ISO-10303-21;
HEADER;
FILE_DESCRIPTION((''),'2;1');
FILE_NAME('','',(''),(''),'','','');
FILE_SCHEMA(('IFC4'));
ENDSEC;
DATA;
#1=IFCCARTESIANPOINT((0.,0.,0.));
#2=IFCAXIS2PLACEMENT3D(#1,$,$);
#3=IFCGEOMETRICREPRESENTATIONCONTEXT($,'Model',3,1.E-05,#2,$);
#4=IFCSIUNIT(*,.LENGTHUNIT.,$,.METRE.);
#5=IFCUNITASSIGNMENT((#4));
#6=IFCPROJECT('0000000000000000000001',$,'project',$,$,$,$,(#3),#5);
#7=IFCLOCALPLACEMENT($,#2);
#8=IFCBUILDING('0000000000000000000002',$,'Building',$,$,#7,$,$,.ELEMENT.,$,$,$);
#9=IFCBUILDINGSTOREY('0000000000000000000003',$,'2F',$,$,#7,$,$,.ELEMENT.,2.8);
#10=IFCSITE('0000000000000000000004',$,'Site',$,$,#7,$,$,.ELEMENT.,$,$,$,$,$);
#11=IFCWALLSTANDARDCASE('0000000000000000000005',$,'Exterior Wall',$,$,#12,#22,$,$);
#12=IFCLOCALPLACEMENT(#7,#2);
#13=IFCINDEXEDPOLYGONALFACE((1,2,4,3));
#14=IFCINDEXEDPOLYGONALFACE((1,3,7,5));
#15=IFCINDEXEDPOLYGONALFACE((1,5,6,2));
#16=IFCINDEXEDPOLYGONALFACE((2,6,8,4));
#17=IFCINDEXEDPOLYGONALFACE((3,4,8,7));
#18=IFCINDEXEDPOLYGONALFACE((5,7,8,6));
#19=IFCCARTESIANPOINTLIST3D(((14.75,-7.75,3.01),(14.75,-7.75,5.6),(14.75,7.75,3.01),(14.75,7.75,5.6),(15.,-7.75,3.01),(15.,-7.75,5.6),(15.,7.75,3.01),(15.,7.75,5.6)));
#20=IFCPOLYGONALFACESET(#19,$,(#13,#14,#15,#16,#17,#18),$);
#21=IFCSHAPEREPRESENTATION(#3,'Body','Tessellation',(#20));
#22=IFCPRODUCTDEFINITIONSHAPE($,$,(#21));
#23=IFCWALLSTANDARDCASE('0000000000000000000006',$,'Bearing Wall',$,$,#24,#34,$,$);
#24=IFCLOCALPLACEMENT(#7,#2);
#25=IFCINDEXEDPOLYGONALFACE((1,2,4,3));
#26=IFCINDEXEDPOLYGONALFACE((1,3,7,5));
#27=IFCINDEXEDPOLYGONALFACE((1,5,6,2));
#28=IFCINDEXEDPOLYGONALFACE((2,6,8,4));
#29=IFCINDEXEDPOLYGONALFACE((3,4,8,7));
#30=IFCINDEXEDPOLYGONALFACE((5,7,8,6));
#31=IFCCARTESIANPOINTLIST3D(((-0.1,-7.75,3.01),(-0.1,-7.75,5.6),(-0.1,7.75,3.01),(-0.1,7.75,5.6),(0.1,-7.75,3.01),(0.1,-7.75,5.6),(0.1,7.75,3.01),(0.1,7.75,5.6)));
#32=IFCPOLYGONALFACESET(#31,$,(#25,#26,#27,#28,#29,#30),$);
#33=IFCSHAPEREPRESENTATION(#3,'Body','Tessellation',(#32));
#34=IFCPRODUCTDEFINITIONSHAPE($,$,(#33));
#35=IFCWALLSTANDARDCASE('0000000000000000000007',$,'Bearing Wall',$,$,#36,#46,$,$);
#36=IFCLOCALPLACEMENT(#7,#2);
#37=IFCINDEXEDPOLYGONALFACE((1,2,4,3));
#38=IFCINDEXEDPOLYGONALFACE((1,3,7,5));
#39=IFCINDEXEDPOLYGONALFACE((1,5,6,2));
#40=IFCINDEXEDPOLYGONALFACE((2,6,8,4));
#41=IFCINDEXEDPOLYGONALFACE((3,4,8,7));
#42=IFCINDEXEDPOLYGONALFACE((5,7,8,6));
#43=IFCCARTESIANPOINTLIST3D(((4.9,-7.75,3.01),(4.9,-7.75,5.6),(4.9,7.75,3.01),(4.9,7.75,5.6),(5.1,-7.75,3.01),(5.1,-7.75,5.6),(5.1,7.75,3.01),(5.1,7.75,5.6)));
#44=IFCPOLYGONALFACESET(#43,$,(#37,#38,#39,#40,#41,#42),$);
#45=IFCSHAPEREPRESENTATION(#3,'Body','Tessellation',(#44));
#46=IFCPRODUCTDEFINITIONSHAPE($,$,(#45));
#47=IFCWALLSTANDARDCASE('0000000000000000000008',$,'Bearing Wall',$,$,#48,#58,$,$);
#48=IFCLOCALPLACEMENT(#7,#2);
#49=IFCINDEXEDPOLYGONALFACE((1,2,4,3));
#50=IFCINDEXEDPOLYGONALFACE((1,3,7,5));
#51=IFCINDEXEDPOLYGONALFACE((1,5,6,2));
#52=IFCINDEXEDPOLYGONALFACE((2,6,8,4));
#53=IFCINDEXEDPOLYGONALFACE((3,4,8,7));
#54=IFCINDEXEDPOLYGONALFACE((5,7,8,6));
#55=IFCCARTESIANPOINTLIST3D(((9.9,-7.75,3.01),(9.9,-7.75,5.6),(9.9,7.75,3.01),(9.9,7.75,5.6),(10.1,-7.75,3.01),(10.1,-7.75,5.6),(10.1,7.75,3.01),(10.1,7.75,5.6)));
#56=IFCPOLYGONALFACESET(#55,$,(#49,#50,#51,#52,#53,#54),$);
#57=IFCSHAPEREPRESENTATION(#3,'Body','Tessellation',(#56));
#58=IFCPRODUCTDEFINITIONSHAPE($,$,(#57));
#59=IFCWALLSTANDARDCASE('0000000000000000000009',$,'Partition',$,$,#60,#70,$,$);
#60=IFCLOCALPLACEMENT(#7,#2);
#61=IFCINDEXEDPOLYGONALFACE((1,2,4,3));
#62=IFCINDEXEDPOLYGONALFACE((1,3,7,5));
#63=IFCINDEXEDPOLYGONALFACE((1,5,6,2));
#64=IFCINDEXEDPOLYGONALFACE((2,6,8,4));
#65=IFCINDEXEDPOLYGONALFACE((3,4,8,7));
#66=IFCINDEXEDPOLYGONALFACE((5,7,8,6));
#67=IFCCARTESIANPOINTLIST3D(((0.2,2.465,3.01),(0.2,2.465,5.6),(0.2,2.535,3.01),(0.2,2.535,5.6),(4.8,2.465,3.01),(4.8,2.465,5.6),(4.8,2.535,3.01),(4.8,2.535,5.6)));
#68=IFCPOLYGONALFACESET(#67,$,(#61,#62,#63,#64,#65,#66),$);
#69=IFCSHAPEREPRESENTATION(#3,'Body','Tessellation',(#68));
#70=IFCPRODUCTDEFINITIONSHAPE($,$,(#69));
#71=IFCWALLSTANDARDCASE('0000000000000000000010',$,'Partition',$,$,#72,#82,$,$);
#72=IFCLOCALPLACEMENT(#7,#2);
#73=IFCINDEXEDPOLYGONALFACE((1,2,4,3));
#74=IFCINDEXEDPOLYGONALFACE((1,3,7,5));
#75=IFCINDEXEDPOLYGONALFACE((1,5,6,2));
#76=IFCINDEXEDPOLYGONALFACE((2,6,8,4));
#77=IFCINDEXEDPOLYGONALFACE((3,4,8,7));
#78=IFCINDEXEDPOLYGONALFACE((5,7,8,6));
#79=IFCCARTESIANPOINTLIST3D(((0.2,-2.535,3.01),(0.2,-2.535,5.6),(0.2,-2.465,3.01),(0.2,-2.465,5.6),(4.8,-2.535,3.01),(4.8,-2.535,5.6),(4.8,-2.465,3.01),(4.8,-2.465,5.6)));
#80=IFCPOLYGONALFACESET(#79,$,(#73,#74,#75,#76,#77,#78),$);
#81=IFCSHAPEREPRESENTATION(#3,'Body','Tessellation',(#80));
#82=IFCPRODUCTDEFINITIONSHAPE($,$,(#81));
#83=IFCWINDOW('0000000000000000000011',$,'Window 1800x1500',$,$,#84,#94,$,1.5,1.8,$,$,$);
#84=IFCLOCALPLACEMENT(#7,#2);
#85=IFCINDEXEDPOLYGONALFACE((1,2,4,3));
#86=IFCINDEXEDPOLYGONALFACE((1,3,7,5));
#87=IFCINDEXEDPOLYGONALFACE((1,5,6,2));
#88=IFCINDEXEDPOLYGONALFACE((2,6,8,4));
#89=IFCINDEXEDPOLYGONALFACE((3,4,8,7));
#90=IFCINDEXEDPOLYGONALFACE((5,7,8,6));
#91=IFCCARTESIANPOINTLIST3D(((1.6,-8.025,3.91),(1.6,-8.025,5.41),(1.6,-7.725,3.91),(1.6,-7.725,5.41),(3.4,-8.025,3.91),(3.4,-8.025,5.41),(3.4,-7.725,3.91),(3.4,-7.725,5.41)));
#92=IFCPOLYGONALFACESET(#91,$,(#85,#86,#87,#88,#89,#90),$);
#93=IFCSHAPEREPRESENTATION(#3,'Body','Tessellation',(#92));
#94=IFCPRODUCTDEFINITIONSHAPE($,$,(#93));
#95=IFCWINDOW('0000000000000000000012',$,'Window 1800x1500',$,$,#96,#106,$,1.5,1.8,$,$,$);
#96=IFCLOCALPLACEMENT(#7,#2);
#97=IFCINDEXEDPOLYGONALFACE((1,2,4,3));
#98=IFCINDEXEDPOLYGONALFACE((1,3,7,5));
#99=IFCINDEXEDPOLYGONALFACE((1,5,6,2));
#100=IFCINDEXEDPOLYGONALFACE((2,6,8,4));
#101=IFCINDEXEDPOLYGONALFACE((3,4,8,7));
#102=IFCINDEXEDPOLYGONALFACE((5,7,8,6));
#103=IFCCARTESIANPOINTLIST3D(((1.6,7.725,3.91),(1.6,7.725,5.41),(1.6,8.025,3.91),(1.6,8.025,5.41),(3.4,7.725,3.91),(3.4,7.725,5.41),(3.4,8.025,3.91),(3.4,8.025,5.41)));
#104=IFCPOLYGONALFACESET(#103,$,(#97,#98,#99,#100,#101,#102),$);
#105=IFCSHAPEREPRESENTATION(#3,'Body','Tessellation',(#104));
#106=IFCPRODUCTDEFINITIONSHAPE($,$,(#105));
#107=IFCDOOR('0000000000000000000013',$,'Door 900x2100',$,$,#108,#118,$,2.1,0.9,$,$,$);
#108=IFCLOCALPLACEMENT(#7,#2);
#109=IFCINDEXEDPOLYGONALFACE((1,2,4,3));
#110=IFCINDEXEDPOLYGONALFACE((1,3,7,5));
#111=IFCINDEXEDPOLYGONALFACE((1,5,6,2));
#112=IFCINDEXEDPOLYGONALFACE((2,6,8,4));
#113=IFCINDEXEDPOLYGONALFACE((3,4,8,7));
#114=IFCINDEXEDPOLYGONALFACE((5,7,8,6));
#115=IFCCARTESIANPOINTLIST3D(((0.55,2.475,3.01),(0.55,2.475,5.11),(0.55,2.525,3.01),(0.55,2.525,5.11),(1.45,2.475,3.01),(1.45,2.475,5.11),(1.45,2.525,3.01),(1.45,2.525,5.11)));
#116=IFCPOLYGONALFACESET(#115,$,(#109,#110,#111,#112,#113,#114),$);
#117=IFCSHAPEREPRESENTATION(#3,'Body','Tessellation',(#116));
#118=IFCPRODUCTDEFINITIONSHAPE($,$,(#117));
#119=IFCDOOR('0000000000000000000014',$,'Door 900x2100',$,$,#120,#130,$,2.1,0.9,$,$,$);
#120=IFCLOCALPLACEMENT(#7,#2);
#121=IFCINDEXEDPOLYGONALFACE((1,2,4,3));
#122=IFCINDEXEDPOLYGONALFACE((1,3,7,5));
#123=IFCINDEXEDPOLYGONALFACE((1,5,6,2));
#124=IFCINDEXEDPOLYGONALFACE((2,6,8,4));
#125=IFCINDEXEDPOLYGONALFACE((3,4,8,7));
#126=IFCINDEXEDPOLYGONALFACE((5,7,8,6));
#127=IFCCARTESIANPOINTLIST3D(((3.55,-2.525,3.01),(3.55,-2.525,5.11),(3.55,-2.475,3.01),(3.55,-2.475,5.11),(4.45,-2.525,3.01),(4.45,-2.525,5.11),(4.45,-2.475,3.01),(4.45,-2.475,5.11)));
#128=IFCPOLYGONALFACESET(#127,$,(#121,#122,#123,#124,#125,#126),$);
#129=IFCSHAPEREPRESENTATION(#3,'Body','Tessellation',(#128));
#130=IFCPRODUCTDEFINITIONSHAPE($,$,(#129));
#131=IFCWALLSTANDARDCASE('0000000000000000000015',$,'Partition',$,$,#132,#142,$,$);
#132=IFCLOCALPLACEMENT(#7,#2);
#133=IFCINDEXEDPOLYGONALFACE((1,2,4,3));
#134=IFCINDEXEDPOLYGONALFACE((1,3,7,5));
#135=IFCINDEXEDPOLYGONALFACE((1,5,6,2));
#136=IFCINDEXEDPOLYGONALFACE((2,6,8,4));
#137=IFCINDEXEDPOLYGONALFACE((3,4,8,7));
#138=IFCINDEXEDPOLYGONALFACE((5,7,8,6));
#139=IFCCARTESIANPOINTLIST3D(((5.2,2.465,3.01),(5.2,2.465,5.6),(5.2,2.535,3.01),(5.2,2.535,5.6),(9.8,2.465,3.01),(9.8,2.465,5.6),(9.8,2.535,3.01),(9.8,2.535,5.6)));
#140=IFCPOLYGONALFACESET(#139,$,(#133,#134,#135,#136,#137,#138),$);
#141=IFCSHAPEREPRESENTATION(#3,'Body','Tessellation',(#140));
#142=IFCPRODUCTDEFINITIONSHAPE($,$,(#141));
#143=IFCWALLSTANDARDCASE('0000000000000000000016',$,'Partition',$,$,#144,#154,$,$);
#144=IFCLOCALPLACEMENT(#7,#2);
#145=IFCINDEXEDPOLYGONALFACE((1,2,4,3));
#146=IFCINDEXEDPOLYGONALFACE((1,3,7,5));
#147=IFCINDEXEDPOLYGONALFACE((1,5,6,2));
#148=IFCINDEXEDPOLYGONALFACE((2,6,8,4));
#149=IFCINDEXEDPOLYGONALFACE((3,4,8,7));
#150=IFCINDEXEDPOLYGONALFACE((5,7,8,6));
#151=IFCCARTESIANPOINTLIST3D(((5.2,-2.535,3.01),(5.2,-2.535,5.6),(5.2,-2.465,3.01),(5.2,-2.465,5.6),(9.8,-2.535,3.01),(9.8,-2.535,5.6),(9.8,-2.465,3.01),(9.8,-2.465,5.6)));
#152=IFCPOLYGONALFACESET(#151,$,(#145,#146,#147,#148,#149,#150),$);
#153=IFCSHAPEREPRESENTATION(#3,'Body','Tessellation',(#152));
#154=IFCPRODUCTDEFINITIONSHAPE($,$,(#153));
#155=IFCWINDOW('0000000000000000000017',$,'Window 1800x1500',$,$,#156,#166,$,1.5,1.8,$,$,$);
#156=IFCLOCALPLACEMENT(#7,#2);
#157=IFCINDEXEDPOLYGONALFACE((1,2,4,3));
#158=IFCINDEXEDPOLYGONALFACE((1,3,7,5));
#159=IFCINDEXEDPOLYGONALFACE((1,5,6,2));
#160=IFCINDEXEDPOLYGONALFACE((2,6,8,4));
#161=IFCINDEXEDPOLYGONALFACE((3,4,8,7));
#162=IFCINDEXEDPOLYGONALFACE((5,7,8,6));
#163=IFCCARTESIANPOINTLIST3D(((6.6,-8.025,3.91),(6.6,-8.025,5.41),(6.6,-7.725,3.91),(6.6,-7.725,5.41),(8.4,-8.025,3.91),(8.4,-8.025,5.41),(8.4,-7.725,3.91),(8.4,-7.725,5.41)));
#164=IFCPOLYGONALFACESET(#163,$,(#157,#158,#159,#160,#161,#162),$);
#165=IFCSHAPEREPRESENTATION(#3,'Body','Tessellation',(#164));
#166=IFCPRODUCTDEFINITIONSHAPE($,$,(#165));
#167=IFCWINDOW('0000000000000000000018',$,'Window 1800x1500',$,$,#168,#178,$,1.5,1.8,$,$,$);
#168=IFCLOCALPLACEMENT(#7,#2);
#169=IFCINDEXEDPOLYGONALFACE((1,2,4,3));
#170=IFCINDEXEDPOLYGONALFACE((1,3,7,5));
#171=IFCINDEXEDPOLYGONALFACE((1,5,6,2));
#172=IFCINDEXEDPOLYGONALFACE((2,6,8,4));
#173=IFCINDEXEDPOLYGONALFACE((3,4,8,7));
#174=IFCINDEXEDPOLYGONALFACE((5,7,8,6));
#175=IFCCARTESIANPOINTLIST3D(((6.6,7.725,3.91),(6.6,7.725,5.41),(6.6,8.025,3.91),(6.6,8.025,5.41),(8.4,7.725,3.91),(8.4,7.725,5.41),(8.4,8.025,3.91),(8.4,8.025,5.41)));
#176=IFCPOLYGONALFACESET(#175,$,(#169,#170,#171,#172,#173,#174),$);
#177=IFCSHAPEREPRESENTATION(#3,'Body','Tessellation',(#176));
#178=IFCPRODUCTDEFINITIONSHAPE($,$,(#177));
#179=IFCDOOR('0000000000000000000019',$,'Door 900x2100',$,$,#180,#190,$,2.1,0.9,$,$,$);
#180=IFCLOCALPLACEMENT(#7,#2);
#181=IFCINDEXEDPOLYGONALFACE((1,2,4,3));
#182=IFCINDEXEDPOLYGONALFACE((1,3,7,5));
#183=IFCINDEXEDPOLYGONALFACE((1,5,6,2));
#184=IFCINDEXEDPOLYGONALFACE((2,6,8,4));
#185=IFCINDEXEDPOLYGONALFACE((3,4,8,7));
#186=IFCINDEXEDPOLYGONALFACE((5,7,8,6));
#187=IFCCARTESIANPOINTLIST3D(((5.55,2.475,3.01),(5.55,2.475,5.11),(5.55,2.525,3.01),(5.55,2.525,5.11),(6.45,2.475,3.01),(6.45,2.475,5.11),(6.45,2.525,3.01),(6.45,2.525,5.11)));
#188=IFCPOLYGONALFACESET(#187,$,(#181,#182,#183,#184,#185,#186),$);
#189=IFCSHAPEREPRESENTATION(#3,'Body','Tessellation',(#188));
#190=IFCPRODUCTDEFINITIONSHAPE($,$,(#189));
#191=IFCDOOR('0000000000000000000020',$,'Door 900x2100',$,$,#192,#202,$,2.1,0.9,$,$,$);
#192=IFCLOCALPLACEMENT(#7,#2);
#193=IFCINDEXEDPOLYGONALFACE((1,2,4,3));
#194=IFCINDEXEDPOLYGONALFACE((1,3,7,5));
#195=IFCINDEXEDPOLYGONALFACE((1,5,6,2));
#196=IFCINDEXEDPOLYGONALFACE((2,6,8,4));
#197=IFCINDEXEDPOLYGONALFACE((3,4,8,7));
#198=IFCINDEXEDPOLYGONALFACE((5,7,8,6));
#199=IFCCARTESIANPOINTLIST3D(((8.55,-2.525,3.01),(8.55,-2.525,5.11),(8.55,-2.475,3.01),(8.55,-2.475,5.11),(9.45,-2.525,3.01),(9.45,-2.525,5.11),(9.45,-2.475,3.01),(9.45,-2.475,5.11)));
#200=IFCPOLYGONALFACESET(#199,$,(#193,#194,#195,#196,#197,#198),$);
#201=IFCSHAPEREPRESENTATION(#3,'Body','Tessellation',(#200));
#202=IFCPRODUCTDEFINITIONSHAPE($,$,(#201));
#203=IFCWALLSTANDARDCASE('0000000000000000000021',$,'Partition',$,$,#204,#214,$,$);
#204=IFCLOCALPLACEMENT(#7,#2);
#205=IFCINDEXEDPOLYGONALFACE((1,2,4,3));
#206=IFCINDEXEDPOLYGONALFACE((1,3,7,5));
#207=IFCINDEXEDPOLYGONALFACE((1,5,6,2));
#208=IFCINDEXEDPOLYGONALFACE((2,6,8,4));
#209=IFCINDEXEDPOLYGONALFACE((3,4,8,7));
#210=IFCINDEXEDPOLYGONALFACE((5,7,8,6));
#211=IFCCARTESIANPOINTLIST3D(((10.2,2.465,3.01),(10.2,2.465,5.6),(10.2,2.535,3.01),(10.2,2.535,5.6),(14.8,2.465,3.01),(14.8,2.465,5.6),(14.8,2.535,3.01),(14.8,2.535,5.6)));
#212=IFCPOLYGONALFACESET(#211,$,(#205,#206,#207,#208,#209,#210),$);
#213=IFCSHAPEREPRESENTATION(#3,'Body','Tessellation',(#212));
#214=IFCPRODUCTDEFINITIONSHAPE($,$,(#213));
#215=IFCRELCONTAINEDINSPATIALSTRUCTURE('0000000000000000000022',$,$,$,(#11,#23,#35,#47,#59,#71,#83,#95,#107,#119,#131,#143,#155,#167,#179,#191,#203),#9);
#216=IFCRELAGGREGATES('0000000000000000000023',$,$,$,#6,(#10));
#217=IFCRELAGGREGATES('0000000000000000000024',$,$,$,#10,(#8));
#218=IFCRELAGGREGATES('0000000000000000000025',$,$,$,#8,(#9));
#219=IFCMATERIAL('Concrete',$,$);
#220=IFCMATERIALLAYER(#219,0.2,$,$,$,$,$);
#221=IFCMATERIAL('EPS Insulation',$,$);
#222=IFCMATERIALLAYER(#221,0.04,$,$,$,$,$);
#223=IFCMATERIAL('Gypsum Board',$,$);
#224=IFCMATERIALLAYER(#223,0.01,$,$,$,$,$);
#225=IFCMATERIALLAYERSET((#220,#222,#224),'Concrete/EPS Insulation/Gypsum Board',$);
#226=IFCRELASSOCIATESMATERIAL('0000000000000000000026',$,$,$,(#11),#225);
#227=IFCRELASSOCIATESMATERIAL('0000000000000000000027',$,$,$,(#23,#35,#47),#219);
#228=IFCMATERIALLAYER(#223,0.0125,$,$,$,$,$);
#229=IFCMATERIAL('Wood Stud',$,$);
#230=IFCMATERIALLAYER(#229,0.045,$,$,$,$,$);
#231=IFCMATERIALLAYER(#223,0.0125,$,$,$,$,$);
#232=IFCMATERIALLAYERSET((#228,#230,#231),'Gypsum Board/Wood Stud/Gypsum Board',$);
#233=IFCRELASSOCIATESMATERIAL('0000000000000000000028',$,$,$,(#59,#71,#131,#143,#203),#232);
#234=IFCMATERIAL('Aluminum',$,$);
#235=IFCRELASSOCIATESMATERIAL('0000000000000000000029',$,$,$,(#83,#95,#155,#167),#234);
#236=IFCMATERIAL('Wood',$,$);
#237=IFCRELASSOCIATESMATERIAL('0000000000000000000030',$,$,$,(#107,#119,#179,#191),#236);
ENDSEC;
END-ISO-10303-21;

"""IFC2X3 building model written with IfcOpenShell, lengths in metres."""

from ifc_helpers import new_model, si_unit, frame, origin, origin_2d, place, context, project, spatial, rectangle, extrude, material, layer, layer_set, layer_usage, element, save


model = new_model("IFC2X3")

# Units and contexts
model_context = context("Model", 3, precision=1e-05, world=origin())
ifc_project = project(units=[si_unit("LENGTHUNIT", "METRE")], contexts=[model_context])

# Site, building, storey
placement = place(None, origin())
site = spatial("IfcSite", under=ifc_project, at=placement, Name="Site", CompositionType="ELEMENT")
building = spatial("IfcBuilding", under=site, at=placement, Name="Building", CompositionType="ELEMENT")
storey = spatial("IfcBuildingStorey", under=building, at=placement, Name="2F", CompositionType="ELEMENT", Elevation=2.8)

# Walls
ifc_material_1 = material(Name="Concrete")
ifc_layer_1 = layer(ifc_material_1, 0.2)
ifc_material_2 = material(Name="EPS Insulation")
ifc_layer_2 = layer(ifc_material_2, 0.04)
ifc_material_3 = material(Name="Gypsum Board")
ifc_layer_3 = layer(ifc_material_3, 0.01)
ifc_layer_set_1 = layer_set([ifc_layer_1, ifc_layer_2, ifc_layer_3], Name="Concrete/EPS Insulation/Gypsum Board")
ifc_layer_usage_1 = layer_usage(ifc_layer_set_1, "AXIS2", "POSITIVE", 0.0)
wall_placement = place(None, frame((14.875, 0.0, 3.01)))
element("IfcWallStandardCase", 1, at=wall_placement, inside=storey, material=ifc_layer_usage_1, Name="Exterior Wall", context=model_context, shape_type="SweptSolid", body=[
    extrude(rectangle(XDim=0.25, YDim=15.5, at=origin_2d()), origin(), (0.0, 0.0, 1.0), 2.59),
])
for number, where, name in (
    (2, (0.0, 0.0, 3.01), "Bearing Wall"),
    (3, (5.0, 0.0, 3.01), "Bearing Wall"),
    (4, (10.0, 0.0, 3.01), "Bearing Wall"),
):
    element("IfcWallStandardCase", number, at=place(None, frame(where)), inside=storey, material=ifc_material_1, Name=name, context=model_context, shape_type="SweptSolid", body=[
        extrude(rectangle(XDim=0.2, YDim=15.5, at=origin_2d()), origin(), (0.0, 0.0, 1.0), 2.59),
    ])
ifc_layer_4 = layer(ifc_material_3, 0.0125)
ifc_material_4 = material(Name="Wood Stud")
ifc_layer_5 = layer(ifc_material_4, 0.045)
ifc_layer_6 = layer(ifc_material_3, 0.0125)
ifc_layer_set_2 = layer_set([ifc_layer_4, ifc_layer_5, ifc_layer_6], Name="Gypsum Board/Wood Stud/Gypsum Board")
ifc_layer_usage_2 = layer_usage(ifc_layer_set_2, "AXIS2", "POSITIVE", 0.0)
for number, where, name in (
    (5, (2.5, 2.5, 3.01), "Partition"),
    (6, (2.5, -2.5, 3.01), "Partition"),
):
    element("IfcWallStandardCase", number, at=place(None, frame(where)), inside=storey, material=ifc_layer_usage_2, Name=name, context=model_context, shape_type="SweptSolid", body=[
        extrude(rectangle(XDim=4.6, YDim=0.07, at=origin_2d()), origin(), (0.0, 0.0, 1.0), 2.59),
    ])

# Windows
ifc_material_5 = material(Name="Aluminum")
for number, where, name in (
    (7, (2.5, -7.875, 3.91), "Window 1800x1500"),
    (8, (2.5, 7.875, 3.91), "Window 1800x1500"),
):
    element("IfcWindow", number, at=place(None, frame(where)), inside=storey, material=ifc_material_5, Name=name, OverallHeight=1.5, OverallWidth=1.8, context=model_context, shape_type="SweptSolid", body=[
        extrude(rectangle(XDim=1.8, YDim=0.3, at=origin_2d()), origin(), (0.0, 0.0, 1.0), 1.5),
    ])

# Doors
ifc_material_6 = material(Name="Wood")
for number, where, name in (
    (9, (1.0, 2.5, 3.01), "Door 900x2100"),
    (10, (4.0, -2.5, 3.01), "Door 900x2100"),
):
    element("IfcDoor", number, at=place(None, frame(where)), inside=storey, material=ifc_material_6, Name=name, OverallHeight=2.1, OverallWidth=0.9, context=model_context, shape_type="SweptSolid", body=[
        extrude(rectangle(XDim=0.9, YDim=0.05, at=origin_2d()), origin(), (0.0, 0.0, 1.0), 2.1),
    ])

# Walls
for number, where, name in (
    (11, (7.5, 2.5, 3.01), "Partition"),
    (12, (7.5, -2.5, 3.01), "Partition"),
):
    element("IfcWallStandardCase", number, at=place(None, frame(where)), inside=storey, material=ifc_layer_usage_2, Name=name, context=model_context, shape_type="SweptSolid", body=[
        extrude(rectangle(XDim=4.6, YDim=0.07, at=origin_2d()), origin(), (0.0, 0.0, 1.0), 2.59),
    ])

# Windows
for number, where, name in (
    (13, (7.5, -7.875, 3.91), "Window 1800x1500"),
    (14, (7.5, 7.875, 3.91), "Window 1800x1500"),
):
    element("IfcWindow", number, at=place(None, frame(where)), inside=storey, material=ifc_material_5, Name=name, OverallHeight=1.5, OverallWidth=1.8, context=model_context, shape_type="SweptSolid", body=[
        extrude(rectangle(XDim=1.8, YDim=0.3, at=origin_2d()), origin(), (0.0, 0.0, 1.0), 1.5),
    ])

# Doors
for number, where, name in (
    (15, (6.0, 2.5, 3.01), "Door 900x2100"),
    (16, (9.0, -2.5, 3.01), "Door 900x2100"),
):
    element("IfcDoor", number, at=place(None, frame(where)), inside=storey, material=ifc_material_6, Name=name, OverallHeight=2.1, OverallWidth=0.9, context=model_context, shape_type="SweptSolid", body=[
        extrude(rectangle(XDim=0.9, YDim=0.05, at=origin_2d()), origin(), (0.0, 0.0, 1.0), 2.1),
    ])

# Wall
for number, where, name in (
    (17, (12.5, 2.5, 3.01), "Partition"),
):
    element("IfcWallStandardCase", number, at=place(None, frame(where)), inside=storey, material=ifc_layer_usage_2, Name=name, context=model_context, shape_type="SweptSolid", body=[
        extrude(rectangle(XDim=4.6, YDim=0.07, at=origin_2d()), origin(), (0.0, 0.0, 1.0), 2.59),
    ])

save(model, "model.ifc")
